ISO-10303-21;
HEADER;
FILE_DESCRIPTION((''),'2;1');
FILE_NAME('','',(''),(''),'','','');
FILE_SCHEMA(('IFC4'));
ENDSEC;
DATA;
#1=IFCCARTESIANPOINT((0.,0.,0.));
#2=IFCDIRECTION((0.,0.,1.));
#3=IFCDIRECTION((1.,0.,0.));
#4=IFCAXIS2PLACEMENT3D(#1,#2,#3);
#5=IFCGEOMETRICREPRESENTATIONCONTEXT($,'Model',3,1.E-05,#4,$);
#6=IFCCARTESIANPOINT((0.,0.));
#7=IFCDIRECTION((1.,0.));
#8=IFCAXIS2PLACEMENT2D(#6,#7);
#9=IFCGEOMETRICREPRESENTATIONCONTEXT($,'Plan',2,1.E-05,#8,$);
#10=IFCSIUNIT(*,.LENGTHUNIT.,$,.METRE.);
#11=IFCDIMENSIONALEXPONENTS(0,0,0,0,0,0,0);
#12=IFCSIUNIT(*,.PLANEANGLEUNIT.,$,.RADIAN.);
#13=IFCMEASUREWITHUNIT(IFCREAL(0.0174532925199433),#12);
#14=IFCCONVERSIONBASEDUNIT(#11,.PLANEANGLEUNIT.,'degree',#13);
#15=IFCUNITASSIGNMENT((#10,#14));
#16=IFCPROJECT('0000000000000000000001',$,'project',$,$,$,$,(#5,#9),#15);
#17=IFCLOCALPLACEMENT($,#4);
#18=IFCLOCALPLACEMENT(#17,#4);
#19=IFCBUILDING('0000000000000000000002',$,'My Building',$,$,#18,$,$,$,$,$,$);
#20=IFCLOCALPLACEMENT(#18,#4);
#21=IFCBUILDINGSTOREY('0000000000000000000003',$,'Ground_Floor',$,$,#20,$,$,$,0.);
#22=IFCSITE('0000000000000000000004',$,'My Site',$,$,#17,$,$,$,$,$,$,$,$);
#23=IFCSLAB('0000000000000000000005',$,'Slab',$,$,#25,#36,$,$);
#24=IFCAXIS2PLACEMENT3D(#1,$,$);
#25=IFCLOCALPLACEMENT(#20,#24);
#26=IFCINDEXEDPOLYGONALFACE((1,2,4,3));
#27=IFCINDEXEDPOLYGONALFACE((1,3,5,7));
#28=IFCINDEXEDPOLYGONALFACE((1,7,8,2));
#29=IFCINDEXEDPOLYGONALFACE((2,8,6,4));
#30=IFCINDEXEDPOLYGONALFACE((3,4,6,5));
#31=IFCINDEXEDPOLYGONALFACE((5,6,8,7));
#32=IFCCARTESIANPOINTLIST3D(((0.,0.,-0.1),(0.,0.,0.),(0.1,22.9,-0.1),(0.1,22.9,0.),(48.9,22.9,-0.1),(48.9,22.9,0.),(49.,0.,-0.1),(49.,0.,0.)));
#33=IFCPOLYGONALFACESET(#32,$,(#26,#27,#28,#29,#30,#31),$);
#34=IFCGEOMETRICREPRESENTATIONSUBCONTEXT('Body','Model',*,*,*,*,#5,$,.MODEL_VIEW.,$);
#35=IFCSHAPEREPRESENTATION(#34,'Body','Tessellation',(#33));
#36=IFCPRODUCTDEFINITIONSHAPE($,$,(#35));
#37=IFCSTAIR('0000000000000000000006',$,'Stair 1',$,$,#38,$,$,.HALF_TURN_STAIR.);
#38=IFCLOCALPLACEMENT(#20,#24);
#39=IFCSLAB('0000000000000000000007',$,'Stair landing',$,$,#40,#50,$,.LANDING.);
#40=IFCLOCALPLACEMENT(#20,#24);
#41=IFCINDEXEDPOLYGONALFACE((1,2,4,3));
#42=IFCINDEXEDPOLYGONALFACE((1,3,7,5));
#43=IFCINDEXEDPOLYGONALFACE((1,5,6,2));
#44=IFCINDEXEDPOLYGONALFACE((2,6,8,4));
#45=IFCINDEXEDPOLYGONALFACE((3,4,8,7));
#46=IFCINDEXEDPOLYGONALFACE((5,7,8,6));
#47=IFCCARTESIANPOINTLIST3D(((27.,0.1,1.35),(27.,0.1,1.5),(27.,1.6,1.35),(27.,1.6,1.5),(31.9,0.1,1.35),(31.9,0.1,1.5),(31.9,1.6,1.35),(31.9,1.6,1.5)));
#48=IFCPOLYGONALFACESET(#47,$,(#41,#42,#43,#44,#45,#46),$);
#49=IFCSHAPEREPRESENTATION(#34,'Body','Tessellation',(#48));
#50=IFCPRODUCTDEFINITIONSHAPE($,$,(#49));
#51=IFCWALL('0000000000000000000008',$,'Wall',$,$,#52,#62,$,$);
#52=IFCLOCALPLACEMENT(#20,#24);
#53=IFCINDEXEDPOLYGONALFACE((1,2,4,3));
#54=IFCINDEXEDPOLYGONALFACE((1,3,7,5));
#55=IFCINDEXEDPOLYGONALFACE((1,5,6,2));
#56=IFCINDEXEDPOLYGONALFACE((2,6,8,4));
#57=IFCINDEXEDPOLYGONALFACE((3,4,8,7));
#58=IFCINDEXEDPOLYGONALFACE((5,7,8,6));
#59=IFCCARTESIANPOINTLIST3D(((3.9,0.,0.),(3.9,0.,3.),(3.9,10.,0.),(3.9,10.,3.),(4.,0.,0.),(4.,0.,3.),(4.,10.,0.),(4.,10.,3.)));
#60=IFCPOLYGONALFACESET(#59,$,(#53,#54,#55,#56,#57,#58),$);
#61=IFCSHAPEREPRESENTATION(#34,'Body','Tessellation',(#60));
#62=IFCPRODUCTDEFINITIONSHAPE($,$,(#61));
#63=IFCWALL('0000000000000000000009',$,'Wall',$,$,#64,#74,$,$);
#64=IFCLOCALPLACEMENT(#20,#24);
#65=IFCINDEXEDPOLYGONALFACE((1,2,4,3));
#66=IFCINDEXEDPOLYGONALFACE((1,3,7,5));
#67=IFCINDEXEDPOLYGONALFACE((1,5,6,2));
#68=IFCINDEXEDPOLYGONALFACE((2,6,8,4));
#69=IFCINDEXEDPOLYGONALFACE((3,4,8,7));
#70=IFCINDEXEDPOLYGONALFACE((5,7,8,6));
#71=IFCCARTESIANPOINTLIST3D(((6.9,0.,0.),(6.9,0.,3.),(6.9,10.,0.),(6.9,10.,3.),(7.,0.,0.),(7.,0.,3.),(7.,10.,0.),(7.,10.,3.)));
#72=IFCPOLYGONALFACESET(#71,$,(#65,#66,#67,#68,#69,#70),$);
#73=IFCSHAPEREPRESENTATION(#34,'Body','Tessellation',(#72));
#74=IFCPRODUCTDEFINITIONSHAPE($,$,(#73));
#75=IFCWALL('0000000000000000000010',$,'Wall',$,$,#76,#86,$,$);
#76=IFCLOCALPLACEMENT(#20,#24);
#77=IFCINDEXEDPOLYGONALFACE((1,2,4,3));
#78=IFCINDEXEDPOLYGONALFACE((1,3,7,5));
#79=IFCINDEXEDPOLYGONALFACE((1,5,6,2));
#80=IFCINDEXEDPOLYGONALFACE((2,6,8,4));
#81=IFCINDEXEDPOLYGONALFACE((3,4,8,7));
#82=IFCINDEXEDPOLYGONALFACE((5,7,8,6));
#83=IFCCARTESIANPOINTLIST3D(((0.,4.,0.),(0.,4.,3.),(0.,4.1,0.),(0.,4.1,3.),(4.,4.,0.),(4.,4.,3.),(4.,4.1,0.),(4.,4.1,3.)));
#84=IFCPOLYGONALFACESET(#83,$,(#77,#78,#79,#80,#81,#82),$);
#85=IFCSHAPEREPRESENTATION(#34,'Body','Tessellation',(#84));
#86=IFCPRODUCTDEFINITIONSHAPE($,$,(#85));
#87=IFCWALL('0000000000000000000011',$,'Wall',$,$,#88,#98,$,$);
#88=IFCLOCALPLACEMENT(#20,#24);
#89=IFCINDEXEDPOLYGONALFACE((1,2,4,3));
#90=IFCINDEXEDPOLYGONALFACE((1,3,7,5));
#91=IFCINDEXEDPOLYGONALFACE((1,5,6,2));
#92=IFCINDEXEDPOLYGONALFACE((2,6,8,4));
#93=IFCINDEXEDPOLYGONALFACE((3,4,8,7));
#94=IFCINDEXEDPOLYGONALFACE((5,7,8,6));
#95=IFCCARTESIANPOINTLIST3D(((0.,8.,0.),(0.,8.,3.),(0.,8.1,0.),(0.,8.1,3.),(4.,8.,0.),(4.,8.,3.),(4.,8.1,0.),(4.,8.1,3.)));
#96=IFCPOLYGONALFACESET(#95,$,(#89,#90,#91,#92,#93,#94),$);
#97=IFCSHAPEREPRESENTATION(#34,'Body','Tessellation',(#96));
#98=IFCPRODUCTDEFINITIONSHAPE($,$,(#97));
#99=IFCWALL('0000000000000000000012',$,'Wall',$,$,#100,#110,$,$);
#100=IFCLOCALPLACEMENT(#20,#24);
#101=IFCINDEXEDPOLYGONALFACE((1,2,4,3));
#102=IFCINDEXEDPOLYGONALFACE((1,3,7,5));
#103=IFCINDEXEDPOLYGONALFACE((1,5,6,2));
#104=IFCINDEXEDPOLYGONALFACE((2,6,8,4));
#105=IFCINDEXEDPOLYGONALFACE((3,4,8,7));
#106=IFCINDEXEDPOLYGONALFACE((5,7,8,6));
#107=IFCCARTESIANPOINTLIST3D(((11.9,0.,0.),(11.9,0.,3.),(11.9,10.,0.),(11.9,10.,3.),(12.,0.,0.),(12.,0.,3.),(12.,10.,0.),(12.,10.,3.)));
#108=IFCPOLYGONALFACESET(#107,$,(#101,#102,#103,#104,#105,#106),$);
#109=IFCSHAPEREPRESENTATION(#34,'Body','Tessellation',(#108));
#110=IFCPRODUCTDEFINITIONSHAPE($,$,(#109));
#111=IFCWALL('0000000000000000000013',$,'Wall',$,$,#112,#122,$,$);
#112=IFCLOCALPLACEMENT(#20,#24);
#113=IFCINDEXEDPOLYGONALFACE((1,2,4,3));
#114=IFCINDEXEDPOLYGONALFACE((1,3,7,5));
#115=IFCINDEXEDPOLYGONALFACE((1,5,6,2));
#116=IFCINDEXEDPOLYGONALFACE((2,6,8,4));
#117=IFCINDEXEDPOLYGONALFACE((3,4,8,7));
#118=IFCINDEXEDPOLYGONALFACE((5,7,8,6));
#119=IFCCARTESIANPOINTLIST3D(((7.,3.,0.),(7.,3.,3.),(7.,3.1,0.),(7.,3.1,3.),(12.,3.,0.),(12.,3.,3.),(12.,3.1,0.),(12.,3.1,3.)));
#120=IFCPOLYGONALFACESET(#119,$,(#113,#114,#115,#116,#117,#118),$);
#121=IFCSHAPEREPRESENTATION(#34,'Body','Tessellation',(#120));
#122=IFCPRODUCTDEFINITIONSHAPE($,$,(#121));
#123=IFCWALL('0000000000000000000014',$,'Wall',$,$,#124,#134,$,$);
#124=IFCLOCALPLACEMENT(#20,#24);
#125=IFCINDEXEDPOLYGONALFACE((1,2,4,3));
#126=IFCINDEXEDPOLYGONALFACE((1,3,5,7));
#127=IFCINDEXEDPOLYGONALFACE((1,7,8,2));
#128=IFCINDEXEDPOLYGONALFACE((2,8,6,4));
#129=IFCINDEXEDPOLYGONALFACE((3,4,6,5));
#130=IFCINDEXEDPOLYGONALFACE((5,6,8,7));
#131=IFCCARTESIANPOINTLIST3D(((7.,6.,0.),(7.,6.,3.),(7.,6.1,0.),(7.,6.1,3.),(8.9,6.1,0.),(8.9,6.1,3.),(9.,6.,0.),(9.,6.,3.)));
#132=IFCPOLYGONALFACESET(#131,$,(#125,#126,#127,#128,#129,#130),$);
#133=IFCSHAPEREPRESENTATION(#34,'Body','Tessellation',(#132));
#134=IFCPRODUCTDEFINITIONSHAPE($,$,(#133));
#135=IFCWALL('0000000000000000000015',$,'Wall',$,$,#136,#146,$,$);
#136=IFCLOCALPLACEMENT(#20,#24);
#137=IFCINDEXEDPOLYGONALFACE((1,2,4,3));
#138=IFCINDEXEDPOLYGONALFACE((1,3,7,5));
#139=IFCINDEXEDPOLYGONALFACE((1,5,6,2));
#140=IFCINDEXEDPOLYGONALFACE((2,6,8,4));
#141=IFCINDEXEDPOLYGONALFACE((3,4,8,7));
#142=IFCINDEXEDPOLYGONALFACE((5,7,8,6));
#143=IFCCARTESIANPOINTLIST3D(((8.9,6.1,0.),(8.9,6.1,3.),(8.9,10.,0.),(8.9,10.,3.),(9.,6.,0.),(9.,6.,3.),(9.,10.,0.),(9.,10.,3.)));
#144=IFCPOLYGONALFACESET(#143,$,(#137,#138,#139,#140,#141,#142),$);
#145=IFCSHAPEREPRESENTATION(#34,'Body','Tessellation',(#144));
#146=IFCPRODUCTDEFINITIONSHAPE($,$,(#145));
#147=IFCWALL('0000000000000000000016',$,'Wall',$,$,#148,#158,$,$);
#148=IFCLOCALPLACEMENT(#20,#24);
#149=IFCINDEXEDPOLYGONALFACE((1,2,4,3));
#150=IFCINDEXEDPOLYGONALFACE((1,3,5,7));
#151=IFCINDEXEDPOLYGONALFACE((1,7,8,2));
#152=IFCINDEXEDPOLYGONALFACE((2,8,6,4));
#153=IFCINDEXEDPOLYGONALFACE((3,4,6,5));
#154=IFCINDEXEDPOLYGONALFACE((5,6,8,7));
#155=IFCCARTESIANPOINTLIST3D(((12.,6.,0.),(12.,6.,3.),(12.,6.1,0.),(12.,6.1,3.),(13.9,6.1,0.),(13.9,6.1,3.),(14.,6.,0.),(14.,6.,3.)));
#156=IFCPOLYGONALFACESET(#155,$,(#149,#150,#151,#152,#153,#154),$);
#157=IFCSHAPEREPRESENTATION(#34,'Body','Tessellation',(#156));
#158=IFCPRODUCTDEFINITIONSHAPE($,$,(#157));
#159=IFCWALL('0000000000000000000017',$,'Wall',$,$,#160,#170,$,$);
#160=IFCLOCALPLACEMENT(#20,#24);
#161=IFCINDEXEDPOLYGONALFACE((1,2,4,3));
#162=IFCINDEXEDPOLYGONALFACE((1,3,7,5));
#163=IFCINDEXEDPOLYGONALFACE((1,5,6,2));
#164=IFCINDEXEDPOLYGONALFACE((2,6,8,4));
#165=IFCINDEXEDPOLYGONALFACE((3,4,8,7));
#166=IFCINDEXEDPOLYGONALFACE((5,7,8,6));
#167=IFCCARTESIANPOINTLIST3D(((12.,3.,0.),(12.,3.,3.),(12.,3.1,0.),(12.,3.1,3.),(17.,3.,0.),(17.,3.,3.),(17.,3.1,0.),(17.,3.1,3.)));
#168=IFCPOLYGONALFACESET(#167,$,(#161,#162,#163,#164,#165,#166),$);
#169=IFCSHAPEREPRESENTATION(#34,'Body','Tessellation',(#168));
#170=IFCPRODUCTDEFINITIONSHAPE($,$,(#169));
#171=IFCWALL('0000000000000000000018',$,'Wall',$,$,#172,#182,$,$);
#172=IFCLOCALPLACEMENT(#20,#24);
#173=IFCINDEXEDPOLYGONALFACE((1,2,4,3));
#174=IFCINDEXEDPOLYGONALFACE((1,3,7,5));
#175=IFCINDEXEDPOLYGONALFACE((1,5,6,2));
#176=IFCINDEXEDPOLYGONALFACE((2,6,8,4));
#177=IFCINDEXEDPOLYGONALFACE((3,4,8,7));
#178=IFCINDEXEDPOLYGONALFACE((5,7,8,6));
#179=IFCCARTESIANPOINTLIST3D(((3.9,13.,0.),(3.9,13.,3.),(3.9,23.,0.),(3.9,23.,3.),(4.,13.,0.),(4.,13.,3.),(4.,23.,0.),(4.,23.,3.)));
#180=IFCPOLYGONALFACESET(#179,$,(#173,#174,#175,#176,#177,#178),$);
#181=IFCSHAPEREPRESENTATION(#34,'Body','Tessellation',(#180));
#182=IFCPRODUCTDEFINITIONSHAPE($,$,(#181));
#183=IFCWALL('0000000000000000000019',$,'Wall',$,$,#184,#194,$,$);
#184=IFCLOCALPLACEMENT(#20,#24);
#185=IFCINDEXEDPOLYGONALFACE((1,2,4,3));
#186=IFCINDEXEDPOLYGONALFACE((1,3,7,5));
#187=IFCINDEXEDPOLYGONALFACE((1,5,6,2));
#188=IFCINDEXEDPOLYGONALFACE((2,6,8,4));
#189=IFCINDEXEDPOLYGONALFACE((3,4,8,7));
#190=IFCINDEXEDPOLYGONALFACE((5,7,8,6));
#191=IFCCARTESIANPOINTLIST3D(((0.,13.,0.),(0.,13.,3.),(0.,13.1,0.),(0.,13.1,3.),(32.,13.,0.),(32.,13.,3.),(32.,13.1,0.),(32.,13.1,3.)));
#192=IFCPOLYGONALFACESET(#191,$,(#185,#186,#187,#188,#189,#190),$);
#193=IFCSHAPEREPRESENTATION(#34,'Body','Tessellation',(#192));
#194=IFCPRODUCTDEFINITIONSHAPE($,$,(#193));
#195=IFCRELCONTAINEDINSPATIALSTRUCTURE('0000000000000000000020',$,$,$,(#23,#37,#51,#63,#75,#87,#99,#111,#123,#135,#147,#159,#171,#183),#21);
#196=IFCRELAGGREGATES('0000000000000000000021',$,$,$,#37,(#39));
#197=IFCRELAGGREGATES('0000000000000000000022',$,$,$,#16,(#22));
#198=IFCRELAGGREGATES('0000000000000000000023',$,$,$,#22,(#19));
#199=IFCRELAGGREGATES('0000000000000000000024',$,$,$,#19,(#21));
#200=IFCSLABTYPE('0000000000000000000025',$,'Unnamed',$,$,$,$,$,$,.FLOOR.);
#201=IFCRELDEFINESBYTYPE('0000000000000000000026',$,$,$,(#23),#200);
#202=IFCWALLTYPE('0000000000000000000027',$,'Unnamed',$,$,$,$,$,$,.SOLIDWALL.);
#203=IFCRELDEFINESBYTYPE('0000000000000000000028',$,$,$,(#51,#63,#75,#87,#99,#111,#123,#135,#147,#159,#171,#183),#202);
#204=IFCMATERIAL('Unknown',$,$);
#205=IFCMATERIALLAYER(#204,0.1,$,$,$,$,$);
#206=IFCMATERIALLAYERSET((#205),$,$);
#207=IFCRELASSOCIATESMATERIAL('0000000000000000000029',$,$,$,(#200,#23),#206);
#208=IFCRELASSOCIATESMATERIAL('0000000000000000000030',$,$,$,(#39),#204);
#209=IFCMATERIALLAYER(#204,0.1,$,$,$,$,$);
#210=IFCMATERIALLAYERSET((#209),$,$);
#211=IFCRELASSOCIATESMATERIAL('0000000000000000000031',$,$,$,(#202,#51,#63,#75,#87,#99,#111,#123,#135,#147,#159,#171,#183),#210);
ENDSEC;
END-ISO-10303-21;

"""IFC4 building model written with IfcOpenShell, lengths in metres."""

from ifc_helpers import new_model, entity, si_unit, converted_unit, frame, frame_2d, origin_with_axes, origin_2d_with_axis, place, context, subcontext, project, spatial, line, indexed_curve, rectangle, outline, extrude, material, layer, layer_set, layer_usage, type_object, element, aggregate, save


model = new_model("IFC4")

# Units and contexts
model_context = context("Model", 3, precision=1e-05, world=origin_with_axes())
plan_context = context("Plan", 2, precision=1e-05, world=origin_2d_with_axis())
body_context = subcontext(model_context, "Body", "Model", "MODEL_VIEW")
ifc_project = project(units=[si_unit("LENGTHUNIT", "METRE"), converted_unit("PLANEANGLEUNIT", "degree", entity("IfcReal", 0.0174532925199433), si_unit("PLANEANGLEUNIT", "RADIAN"), dimensions=[0, 0, 0, 0, 0, 0, 0])], contexts=[model_context, plan_context])

# Site, building, storey
site_placement = place(None, origin_with_axes())
site = spatial("IfcSite", under=ifc_project, at=site_placement, Name="My Site")
building_placement = place(site_placement, origin_with_axes())
building = spatial("IfcBuilding", under=site, at=building_placement, Name="My Building")
storey_placement = place(building_placement, origin_with_axes())
storey = spatial("IfcBuildingStorey", under=building, at=storey_placement, Name="Ground_Floor", Elevation=0.0)

# Slab
ifc_material = material(Name="Unknown")
ifc_layer_1 = layer(ifc_material, 0.1)
ifc_layer_set_1 = layer_set([ifc_layer_1])
ifc_layer_usage_1 = layer_usage(ifc_layer_set_1, "AXIS3", "POSITIVE", -0.1)
slab_type = type_object("IfcSlabType", Name="Unnamed", PredefinedType="FLOOR", material=ifc_layer_set_1)
slab_1_placement = place(storey_placement, frame((0.1, 22.9, 0.0), z_axis=(0.0, 0.0, 1.0), x_axis=(1.0, 0.0, 0.0)))
element("IfcSlab", 1, at=slab_1_placement, inside=storey, type_object=slab_type, material=ifc_layer_usage_1, Name="Slab", context=body_context, shape_type="SweptSolid", body=[
    extrude(outline(indexed_curve([(0.0, 0.0), (48.8, 0.0), (48.9, -22.9), (-0.1, -22.9), (0.0, 0.0)])), frame((0.0, 0.0, -0.1), z_axis=(0.0, 0.0, 1.0), x_axis=(1.0, 0.0, 0.0)), (0.0, 0.0, 1.0), 0.1),
])

# Stair, slab
stair_placement = place(storey_placement, origin_with_axes())
stair = element("IfcStair", 2, at=stair_placement, inside=storey, Name="Stair 1", PredefinedType="HALF_TURN_STAIR")
slab_2_placement = place(stair_placement, origin_with_axes())
slab_2 = element("IfcSlab", 3, at=slab_2_placement, material=ifc_material, Name="Stair landing", PredefinedType="LANDING", context=body_context, shape_type="SweptSolid", body=[
    extrude(rectangle(XDim=4.9, YDim=1.5, at=frame_2d((29.45, 0.85))), frame((0.0, 0.0, 1.35)), (0.0, 0.0, 1.0), 0.15),
])

# Walls
ifc_layer_2 = layer(ifc_material, 0.1)
ifc_layer_set_2 = layer_set([ifc_layer_2])
ifc_layer_usage_2 = layer_usage(ifc_layer_set_2, "AXIS2", "POSITIVE", 0.0)
wall_type = type_object("IfcWallType", Name="Unnamed", PredefinedType="SOLIDWALL", material=ifc_layer_set_2)
wall_1_placement = place(storey_placement, frame((4.0, 0.0, 0.0), z_axis=(0.0, 0.0, 1.0), x_axis=(0.0, 1.0, 0.0)))
element("IfcWall", 4, at=wall_1_placement, inside=storey, type_object=wall_type, material=ifc_layer_usage_2, Name="Wall", context=body_context, shape_type="SweptSolid", body=[
    extrude(outline(indexed_curve([(0.0, 0.0), (0.0, 0.1), (10.0, 0.1), (10.0, 0.0)], segments=[line(1, 2, 3, 4, 1)])), origin_with_axes(), (0.0, 0.0, 1.0), 3.0),
])
ifc_layer_usage_3 = layer_usage(ifc_layer_set_2, "AXIS2", "POSITIVE", 0.0)
wall_2_placement = place(storey_placement, frame((7.0, 0.0, 0.0), z_axis=(0.0, 0.0, 1.0), x_axis=(0.0, 1.0, 0.0)))
element("IfcWall", 5, at=wall_2_placement, inside=storey, type_object=wall_type, material=ifc_layer_usage_3, Name="Wall", context=body_context, shape_type="SweptSolid", body=[
    extrude(outline(indexed_curve([(0.0, 0.0), (0.0, 0.1), (10.0, 0.1), (10.0, 0.0)], segments=[line(1, 2, 3, 4, 1)])), origin_with_axes(), (0.0, 0.0, 1.0), 3.0),
])
ifc_layer_usage_4 = layer_usage(ifc_layer_set_2, "AXIS2", "POSITIVE", 0.0)
wall_3_placement = place(storey_placement, frame((0.0, 4.0, 0.0), z_axis=(0.0, 0.0, 1.0), x_axis=(1.0, 0.0, 0.0)))
element("IfcWall", 6, at=wall_3_placement, inside=storey, type_object=wall_type, material=ifc_layer_usage_4, Name="Wall", context=body_context, shape_type="SweptSolid", body=[
    extrude(outline(indexed_curve([(0.0, 0.0), (0.0, 0.1), (4.0, 0.1), (4.0, 0.0)], segments=[line(1, 2, 3, 4, 1)])), origin_with_axes(), (0.0, 0.0, 1.0), 3.0),
])
ifc_layer_usage_5 = layer_usage(ifc_layer_set_2, "AXIS2", "POSITIVE", 0.0)
wall_4_placement = place(storey_placement, frame((0.0, 8.0, 0.0), z_axis=(0.0, 0.0, 1.0), x_axis=(1.0, 0.0, 0.0)))
element("IfcWall", 7, at=wall_4_placement, inside=storey, type_object=wall_type, material=ifc_layer_usage_5, Name="Wall", context=body_context, shape_type="SweptSolid", body=[
    extrude(outline(indexed_curve([(0.0, 0.0), (0.0, 0.1), (4.0, 0.1), (4.0, 0.0)], segments=[line(1, 2, 3, 4, 1)])), origin_with_axes(), (0.0, 0.0, 1.0), 3.0),
])
ifc_layer_usage_6 = layer_usage(ifc_layer_set_2, "AXIS2", "POSITIVE", 0.0)
wall_5_placement = place(storey_placement, frame((12.0, 0.0, 0.0), z_axis=(0.0, 0.0, 1.0), x_axis=(0.0, 1.0, 0.0)))
element("IfcWall", 8, at=wall_5_placement, inside=storey, type_object=wall_type, material=ifc_layer_usage_6, Name="Wall", context=body_context, shape_type="SweptSolid", body=[
    extrude(outline(indexed_curve([(0.0, 0.0), (0.0, 0.1), (10.0, 0.1), (10.0, 0.0)], segments=[line(1, 2, 3, 4, 1)])), origin_with_axes(), (0.0, 0.0, 1.0), 3.0),
])
ifc_layer_usage_7 = layer_usage(ifc_layer_set_2, "AXIS2", "POSITIVE", 0.0)
wall_6_placement = place(storey_placement, frame((7.0, 3.0, 0.0), z_axis=(0.0, 0.0, 1.0), x_axis=(1.0, 0.0, 0.0)))
element("IfcWall", 9, at=wall_6_placement, inside=storey, type_object=wall_type, material=ifc_layer_usage_7, Name="Wall", context=body_context, shape_type="SweptSolid", body=[
    extrude(outline(indexed_curve([(0.0, 0.0), (0.0, 0.1), (5.0, 0.1), (5.0, 0.0)], segments=[line(1, 2, 3, 4, 1)])), origin_with_axes(), (0.0, 0.0, 1.0), 3.0),
])
ifc_layer_usage_8 = layer_usage(ifc_layer_set_2, "AXIS2", "POSITIVE", 0.0)
wall_7_placement = place(storey_placement, frame((7.0, 6.0, 0.0), z_axis=(0.0, 0.0, 1.0), x_axis=(1.0, 0.0, 0.0)))
element("IfcWall", 10, at=wall_7_placement, inside=storey, type_object=wall_type, material=ifc_layer_usage_8, Name="Wall", context=body_context, shape_type="SweptSolid", body=[
    extrude(outline(indexed_curve([(0.0, 0.0), (0.0, 0.1), (1.9, 0.1), (2.0, 0.0)], segments=[line(1, 2, 3, 4, 1)])), origin_with_axes(), (0.0, 0.0, 1.0), 3.0),
])
ifc_layer_usage_9 = layer_usage(ifc_layer_set_2, "AXIS2", "POSITIVE", 0.0)
wall_8_placement = place(storey_placement, frame((9.0, 6.0, 0.0), z_axis=(0.0, 0.0, 1.0), x_axis=(0.0, 1.0, 0.0)))
element("IfcWall", 11, at=wall_8_placement, inside=storey, type_object=wall_type, material=ifc_layer_usage_9, Name="Wall", context=body_context, shape_type="SweptSolid", body=[
    extrude(outline(indexed_curve([(0.0, 0.0), (0.1, 0.1), (4.0, 0.1), (4.0, 0.0)], segments=[line(1, 2, 3, 4, 1)])), origin_with_axes(), (0.0, 0.0, 1.0), 3.0),
])
ifc_layer_usage_10 = layer_usage(ifc_layer_set_2, "AXIS2", "POSITIVE", 0.0)
wall_9_placement = place(storey_placement, frame((12.0, 6.0, 0.0), z_axis=(0.0, 0.0, 1.0), x_axis=(1.0, 0.0, 0.0)))
element("IfcWall", 12, at=wall_9_placement, inside=storey, type_object=wall_type, material=ifc_layer_usage_10, Name="Wall", context=body_context, shape_type="SweptSolid", body=[
    extrude(outline(indexed_curve([(0.0, 0.0), (0.0, 0.1), (1.9, 0.1), (2.0, 0.0)], segments=[line(1, 2, 3, 4, 1)])), origin_with_axes(), (0.0, 0.0, 1.0), 3.0),
])
ifc_layer_usage_11 = layer_usage(ifc_layer_set_2, "AXIS2", "POSITIVE", 0.0)
wall_10_placement = place(storey_placement, frame((12.0, 3.0, 0.0), z_axis=(0.0, 0.0, 1.0), x_axis=(1.0, 0.0, 0.0)))
element("IfcWall", 13, at=wall_10_placement, inside=storey, type_object=wall_type, material=ifc_layer_usage_11, Name="Wall", context=body_context, shape_type="SweptSolid", body=[
    extrude(outline(indexed_curve([(0.0, 0.0), (0.0, 0.1), (5.0, 0.1), (5.0, 0.0)], segments=[line(1, 2, 3, 4, 1)])), origin_with_axes(), (0.0, 0.0, 1.0), 3.0),
])
ifc_layer_usage_12 = layer_usage(ifc_layer_set_2, "AXIS2", "POSITIVE", 0.0)
wall_11_placement = place(storey_placement, frame((4.0, 13.0, 0.0), z_axis=(0.0, 0.0, 1.0), x_axis=(0.0, 1.0, 0.0)))
element("IfcWall", 14, at=wall_11_placement, inside=storey, type_object=wall_type, material=ifc_layer_usage_12, Name="Wall", context=body_context, shape_type="SweptSolid", body=[
    extrude(outline(indexed_curve([(0.0, 0.0), (0.0, 0.1), (10.0, 0.1), (10.0, 0.0)], segments=[line(1, 2, 3, 4, 1)])), origin_with_axes(), (0.0, 0.0, 1.0), 3.0),
])
ifc_layer_usage_13 = layer_usage(ifc_layer_set_2, "AXIS2", "POSITIVE", 0.0)
wall_12_placement = place(storey_placement, frame((0.0, 13.0, 0.0), z_axis=(0.0, 0.0, 1.0), x_axis=(1.0, 0.0, 0.0)))
element("IfcWall", 15, at=wall_12_placement, inside=storey, type_object=wall_type, material=ifc_layer_usage_13, Name="Wall", context=body_context, shape_type="SweptSolid", body=[
    extrude(outline(indexed_curve([(0.0, 0.0), (0.0, 0.1), (32.0, 0.1), (32.0, 0.0)], segments=[line(1, 2, 3, 4, 1)])), origin_with_axes(), (0.0, 0.0, 1.0), 3.0),
])

aggregate(stair, [slab_2])

save(model, "model.ifc")
